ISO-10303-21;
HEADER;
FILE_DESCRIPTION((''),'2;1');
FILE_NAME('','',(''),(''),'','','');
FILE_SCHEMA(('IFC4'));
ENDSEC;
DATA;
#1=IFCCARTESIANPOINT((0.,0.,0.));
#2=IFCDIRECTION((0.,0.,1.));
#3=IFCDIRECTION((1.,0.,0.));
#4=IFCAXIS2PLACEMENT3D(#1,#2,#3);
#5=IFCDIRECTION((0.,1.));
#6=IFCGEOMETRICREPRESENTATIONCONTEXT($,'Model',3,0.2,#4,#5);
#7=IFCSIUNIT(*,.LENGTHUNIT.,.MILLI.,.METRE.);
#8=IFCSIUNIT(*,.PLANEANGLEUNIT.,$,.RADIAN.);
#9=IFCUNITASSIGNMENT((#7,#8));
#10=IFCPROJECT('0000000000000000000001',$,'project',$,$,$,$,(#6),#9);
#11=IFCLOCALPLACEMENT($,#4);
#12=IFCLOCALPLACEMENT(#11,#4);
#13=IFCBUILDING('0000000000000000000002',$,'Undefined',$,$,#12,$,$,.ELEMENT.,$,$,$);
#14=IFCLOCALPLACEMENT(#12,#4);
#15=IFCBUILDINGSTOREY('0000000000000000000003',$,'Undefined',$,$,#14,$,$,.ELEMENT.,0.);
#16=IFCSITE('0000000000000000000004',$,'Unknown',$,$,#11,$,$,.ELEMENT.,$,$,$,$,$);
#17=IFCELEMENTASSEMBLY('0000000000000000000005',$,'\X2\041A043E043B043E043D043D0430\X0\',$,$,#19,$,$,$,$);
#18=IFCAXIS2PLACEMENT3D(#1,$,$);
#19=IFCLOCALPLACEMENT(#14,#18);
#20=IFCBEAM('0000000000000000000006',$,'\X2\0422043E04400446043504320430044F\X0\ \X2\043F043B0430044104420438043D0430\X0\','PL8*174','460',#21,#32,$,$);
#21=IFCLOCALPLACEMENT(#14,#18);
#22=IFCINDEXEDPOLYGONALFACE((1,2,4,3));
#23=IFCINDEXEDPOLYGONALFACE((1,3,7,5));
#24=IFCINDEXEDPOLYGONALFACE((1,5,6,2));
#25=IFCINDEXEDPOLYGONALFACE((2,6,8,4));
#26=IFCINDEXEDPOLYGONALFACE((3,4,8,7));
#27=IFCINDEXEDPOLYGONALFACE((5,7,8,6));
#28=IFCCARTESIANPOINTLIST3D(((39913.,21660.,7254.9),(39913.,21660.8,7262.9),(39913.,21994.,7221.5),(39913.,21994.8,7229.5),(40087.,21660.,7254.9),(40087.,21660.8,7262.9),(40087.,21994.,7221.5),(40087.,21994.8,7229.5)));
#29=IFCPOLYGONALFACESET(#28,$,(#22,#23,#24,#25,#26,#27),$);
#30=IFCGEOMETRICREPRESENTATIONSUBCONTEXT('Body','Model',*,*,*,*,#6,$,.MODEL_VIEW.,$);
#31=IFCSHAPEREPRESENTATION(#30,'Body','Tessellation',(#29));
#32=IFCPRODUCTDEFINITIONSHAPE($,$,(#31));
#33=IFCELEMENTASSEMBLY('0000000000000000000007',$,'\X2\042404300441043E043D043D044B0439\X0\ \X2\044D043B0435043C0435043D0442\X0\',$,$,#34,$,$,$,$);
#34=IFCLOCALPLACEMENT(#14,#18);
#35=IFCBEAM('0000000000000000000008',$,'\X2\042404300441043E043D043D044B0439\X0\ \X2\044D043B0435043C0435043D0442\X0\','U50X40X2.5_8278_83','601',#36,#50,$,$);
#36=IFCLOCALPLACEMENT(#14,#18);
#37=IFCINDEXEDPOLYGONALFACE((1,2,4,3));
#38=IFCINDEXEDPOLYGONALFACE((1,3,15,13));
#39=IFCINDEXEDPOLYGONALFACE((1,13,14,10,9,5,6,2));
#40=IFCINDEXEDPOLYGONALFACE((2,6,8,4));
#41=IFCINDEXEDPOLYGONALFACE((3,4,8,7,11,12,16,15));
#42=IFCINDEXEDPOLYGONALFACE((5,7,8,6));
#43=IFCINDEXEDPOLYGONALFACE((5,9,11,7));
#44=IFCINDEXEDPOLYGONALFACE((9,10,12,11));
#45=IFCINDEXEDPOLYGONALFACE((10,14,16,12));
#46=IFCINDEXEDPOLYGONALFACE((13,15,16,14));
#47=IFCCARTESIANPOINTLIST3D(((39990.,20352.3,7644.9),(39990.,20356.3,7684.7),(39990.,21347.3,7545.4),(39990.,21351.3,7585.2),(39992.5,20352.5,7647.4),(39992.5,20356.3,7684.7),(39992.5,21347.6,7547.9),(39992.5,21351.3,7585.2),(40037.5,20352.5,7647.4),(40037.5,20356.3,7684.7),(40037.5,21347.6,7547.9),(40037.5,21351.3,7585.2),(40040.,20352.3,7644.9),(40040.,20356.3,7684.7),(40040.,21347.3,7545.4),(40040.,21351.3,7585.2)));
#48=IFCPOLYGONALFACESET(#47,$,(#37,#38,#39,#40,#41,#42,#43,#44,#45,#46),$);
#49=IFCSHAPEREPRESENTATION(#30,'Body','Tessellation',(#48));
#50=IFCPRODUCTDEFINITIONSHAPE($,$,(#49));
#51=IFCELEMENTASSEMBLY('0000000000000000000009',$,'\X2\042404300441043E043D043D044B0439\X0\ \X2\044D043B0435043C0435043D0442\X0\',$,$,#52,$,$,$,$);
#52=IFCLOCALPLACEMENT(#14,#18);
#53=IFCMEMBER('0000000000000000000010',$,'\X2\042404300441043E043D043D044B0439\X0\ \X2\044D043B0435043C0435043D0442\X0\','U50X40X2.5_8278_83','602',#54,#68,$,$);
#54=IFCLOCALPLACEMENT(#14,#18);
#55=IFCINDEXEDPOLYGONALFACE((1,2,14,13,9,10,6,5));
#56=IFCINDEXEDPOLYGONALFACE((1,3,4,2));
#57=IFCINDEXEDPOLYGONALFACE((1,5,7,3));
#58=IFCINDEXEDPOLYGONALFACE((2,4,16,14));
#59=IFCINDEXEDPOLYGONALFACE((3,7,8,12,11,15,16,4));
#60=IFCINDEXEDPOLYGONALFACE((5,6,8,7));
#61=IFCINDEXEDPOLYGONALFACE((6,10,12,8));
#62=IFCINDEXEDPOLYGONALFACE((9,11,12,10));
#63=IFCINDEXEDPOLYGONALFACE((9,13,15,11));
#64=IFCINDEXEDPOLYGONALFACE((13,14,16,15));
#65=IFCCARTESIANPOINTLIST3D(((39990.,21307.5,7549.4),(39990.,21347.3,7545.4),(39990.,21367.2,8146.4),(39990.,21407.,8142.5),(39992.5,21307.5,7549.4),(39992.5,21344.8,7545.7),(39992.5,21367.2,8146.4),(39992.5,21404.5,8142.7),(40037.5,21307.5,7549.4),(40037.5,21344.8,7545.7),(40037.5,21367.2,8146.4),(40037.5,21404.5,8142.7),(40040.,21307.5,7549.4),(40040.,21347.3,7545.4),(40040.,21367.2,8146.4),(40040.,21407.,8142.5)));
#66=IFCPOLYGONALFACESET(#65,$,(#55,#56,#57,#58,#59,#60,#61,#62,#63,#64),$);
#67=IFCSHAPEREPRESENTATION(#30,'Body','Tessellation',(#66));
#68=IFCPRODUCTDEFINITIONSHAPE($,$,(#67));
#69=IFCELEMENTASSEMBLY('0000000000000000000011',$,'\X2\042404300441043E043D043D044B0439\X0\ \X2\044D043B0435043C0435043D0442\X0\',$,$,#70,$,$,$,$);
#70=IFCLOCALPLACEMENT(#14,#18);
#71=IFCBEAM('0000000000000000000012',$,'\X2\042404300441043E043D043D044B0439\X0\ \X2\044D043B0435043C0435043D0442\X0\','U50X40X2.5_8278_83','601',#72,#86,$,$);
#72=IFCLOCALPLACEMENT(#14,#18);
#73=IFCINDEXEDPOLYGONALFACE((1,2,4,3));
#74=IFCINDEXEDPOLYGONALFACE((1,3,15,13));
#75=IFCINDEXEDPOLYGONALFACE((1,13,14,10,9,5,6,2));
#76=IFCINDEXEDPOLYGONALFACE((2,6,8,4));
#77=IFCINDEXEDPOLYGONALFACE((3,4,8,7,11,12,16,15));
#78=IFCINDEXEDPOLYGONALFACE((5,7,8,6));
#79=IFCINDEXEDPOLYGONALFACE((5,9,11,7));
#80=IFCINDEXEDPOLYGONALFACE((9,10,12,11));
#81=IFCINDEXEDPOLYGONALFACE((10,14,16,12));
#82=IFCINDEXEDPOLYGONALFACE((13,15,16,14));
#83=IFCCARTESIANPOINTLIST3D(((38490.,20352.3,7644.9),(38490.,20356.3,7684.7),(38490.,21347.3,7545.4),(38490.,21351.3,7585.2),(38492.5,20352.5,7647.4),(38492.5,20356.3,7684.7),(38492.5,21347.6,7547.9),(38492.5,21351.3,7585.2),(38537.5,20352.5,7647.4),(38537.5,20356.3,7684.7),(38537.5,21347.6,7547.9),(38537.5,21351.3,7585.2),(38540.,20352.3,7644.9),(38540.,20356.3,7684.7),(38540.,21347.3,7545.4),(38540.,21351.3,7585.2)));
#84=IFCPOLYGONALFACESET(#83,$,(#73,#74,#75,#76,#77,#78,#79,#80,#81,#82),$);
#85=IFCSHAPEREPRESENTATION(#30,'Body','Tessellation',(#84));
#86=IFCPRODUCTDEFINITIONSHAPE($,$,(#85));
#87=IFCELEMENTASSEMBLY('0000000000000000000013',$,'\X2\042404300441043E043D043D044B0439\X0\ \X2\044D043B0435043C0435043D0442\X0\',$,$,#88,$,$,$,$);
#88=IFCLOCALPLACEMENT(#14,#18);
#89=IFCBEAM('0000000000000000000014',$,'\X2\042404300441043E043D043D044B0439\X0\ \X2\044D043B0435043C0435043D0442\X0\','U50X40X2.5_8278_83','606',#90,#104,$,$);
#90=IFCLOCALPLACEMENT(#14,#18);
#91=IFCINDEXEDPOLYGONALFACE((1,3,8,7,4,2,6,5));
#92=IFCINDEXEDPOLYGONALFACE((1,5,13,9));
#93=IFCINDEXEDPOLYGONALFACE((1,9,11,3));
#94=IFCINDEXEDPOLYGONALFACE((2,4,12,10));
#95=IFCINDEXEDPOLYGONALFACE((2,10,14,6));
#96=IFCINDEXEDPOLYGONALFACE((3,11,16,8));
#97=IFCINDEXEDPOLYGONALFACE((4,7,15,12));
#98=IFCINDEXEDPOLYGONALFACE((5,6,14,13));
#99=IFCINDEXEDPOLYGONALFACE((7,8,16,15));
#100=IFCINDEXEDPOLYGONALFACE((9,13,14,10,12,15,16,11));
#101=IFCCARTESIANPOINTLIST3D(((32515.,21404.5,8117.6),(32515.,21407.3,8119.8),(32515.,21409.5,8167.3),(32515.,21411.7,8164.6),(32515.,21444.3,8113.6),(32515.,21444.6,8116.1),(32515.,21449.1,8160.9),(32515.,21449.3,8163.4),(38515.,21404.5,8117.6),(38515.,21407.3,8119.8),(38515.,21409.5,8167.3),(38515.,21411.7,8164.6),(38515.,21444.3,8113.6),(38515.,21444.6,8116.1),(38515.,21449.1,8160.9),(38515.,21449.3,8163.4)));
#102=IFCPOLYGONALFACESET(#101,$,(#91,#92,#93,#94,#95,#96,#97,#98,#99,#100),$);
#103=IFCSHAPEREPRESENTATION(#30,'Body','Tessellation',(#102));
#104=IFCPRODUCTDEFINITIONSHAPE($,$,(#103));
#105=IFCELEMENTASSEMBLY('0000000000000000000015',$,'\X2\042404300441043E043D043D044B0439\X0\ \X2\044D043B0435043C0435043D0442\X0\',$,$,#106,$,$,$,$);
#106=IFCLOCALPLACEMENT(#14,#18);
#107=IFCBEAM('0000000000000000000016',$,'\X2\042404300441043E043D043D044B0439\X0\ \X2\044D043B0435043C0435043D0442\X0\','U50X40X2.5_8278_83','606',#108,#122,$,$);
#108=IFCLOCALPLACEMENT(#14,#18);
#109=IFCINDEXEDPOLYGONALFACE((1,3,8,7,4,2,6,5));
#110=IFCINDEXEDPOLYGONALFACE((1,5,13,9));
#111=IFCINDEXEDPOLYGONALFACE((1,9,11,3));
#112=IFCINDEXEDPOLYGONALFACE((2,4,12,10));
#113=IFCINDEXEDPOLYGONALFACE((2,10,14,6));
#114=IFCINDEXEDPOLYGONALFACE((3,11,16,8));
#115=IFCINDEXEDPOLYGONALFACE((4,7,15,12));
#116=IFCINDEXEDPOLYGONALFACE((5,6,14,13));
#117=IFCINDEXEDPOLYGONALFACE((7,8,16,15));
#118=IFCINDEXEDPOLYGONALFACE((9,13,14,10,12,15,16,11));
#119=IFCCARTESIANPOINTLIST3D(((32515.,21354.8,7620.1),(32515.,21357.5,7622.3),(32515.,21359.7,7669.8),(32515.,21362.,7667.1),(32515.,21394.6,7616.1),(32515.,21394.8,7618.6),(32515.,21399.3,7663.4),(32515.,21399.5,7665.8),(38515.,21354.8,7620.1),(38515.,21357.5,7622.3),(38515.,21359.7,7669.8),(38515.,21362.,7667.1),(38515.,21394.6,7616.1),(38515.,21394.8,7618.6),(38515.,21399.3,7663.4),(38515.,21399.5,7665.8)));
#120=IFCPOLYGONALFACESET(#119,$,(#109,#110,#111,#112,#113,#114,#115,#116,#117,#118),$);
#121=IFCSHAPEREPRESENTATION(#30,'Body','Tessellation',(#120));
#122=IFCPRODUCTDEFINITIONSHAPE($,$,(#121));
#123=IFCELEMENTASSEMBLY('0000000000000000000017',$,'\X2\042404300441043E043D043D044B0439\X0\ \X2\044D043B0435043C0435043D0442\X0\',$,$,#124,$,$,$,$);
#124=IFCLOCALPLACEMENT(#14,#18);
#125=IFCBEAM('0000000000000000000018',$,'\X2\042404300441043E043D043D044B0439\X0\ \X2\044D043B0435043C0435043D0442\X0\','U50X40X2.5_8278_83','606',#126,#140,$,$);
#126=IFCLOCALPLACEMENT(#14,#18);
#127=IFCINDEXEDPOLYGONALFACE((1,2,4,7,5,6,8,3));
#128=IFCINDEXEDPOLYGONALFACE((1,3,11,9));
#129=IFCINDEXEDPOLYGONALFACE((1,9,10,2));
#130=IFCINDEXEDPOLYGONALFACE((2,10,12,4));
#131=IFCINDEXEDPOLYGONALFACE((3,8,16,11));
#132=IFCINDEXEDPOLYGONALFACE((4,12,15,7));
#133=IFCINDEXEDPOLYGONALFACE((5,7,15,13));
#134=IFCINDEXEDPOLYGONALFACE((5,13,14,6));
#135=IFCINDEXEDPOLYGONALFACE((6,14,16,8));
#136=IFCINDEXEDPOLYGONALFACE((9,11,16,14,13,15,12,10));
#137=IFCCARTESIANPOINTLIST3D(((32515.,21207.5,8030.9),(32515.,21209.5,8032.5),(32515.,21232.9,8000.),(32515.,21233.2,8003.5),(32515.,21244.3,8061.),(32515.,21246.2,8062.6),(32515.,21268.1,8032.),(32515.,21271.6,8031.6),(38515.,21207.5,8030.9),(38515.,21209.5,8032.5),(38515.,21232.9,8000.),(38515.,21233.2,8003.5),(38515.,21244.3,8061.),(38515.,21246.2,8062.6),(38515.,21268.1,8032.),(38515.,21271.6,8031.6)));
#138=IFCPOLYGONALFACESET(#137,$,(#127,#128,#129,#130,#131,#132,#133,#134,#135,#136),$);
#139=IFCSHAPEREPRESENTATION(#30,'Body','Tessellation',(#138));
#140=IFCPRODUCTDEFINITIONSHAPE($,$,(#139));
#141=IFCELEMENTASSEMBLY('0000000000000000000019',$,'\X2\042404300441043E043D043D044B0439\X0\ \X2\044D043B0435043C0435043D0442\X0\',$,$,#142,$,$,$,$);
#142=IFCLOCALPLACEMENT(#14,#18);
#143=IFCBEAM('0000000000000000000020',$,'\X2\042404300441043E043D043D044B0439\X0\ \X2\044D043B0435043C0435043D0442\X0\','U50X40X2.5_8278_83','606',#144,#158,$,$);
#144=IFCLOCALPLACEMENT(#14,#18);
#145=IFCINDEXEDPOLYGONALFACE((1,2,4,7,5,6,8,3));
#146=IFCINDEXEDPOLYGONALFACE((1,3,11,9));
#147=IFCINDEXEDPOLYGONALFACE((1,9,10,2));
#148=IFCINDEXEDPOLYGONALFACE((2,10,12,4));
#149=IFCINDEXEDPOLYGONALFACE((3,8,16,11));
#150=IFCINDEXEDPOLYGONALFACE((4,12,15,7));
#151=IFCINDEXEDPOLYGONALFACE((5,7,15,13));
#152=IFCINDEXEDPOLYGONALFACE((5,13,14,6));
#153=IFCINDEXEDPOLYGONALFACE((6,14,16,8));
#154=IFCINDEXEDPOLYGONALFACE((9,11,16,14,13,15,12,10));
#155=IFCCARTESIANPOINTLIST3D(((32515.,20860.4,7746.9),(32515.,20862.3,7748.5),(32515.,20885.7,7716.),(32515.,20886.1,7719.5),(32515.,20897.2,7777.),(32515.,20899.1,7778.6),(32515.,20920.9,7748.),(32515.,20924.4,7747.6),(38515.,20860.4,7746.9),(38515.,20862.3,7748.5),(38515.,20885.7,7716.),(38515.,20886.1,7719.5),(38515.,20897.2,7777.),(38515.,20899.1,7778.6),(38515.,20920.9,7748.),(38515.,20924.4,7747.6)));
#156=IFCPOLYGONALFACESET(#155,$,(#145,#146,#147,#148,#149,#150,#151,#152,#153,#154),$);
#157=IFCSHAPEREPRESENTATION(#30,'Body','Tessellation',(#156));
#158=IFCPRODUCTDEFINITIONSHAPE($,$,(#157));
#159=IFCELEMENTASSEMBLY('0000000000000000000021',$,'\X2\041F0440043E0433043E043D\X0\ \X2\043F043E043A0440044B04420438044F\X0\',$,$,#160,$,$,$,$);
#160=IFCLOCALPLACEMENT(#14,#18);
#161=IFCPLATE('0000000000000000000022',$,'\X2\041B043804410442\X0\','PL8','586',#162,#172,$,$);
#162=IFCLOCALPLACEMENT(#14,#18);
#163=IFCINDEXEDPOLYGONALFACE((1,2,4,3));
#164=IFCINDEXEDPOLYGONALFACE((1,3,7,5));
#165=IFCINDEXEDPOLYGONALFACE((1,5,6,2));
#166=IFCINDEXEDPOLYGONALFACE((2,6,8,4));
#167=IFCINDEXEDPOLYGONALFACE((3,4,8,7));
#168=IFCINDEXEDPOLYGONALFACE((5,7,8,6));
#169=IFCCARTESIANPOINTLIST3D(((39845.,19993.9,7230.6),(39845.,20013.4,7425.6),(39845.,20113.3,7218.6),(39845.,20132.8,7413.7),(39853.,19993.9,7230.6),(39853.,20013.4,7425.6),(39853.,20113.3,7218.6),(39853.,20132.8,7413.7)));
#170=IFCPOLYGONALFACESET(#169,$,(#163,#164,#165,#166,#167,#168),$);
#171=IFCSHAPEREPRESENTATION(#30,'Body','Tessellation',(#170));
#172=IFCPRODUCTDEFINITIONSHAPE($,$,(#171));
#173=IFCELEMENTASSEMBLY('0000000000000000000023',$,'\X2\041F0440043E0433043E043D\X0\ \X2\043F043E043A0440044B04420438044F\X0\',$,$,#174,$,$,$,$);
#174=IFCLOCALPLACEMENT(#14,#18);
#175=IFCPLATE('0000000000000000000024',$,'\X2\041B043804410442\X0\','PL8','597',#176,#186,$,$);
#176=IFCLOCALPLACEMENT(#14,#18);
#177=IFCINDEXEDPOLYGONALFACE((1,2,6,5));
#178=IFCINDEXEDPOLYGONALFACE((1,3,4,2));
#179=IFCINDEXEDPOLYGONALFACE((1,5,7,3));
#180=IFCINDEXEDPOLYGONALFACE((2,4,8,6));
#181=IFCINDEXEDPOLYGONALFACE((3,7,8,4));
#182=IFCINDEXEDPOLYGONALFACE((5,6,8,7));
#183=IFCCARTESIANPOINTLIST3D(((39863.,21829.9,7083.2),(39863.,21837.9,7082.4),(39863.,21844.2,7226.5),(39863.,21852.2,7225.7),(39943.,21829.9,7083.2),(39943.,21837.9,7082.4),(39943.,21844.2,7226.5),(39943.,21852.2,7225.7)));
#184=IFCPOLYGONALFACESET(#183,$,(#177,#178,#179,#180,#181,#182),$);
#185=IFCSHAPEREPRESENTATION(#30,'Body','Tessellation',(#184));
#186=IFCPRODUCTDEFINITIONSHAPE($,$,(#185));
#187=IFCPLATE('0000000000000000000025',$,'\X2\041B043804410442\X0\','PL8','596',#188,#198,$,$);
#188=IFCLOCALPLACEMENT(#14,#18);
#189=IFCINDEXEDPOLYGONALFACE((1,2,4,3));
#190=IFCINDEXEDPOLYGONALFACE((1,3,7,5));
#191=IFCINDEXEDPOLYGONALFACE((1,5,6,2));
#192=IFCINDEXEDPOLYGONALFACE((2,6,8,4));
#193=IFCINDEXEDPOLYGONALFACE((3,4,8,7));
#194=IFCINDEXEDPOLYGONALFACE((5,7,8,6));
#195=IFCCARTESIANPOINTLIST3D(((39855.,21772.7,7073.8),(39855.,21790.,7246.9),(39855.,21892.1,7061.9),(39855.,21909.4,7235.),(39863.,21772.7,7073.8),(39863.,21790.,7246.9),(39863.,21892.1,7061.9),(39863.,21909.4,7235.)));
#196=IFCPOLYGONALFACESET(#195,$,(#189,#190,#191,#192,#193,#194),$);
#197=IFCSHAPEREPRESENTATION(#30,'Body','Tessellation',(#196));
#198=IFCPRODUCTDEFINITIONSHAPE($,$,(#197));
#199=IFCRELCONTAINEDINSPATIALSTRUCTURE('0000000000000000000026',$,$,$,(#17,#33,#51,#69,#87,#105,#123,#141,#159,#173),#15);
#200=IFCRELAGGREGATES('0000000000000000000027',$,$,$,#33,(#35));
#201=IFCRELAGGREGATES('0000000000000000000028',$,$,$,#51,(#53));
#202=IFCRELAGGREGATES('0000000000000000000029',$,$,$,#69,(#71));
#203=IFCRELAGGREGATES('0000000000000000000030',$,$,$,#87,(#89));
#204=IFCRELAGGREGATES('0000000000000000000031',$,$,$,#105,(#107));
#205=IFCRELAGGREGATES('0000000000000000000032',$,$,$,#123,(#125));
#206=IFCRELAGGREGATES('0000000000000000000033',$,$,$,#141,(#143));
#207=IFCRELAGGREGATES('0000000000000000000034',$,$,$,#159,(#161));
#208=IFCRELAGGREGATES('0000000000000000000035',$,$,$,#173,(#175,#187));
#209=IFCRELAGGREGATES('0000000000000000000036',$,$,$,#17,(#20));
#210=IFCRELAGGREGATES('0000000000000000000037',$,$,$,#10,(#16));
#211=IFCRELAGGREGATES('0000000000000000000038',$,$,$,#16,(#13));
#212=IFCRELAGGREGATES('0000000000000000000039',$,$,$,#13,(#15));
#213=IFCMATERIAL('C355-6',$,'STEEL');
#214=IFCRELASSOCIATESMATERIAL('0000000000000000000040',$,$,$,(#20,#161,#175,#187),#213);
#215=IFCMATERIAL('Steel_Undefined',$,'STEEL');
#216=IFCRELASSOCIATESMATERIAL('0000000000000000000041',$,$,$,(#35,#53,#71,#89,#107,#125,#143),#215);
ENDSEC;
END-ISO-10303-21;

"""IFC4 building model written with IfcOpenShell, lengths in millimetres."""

from ifc_helpers import new_model, si_unit, direction, frame, origin_with_axes, place, context, subcontext, project, spatial, line, indexed_curve, outline, extrude, material, element, aggregate, save


model = new_model("IFC4")

# Units and contexts
model_context = context("Model", 3, precision=0.2, world=origin_with_axes(), true_north=direction((0.0, 1.0)))
body_context = subcontext(model_context, "Body", "Model", "MODEL_VIEW")
ifc_project = project(units=[si_unit("LENGTHUNIT", "METRE", prefix="MILLI"), si_unit("PLANEANGLEUNIT", "RADIAN")], contexts=[model_context])

# Site, building, storey
site_placement = place(None, origin_with_axes())
site = spatial("IfcSite", under=ifc_project, at=site_placement, Name="Unknown", CompositionType="ELEMENT")
building_placement = place(site_placement, origin_with_axes())
building = spatial("IfcBuilding", under=site, at=building_placement, Name="Undefined", CompositionType="ELEMENT")
storey_placement = place(building_placement, origin_with_axes())
storey = spatial("IfcBuildingStorey", under=building, at=storey_placement, Name="Undefined", CompositionType="ELEMENT", Elevation=0.0)

# Element assemblies, beams
assembly_1_placement = place(storey_placement, frame((40000.0, 21827.0, -200.0), z_axis=(-1.0, 0.0, 0.0), x_axis=(0.0, 0.0, 1.0)))
assembly_1 = element("IfcElementAssembly", 1, at=assembly_1_placement, inside=storey, Name="Колонна")
ifc_material_1 = material(Name="C355-6", Category="STEEL")
beam_1_placement = place(assembly_1_placement, frame((7458.9, -166.6, 0.0), z_axis=(-0.995037, -0.099504, 0.0), x_axis=(-0.099504, 0.995037, 0.0)))
beam_1 = element("IfcBeam", 2, at=beam_1_placement, material=ifc_material_1, Name="Торцевая пластина", Description="PL8*174", ObjectType="460", context=body_context, shape_type="SolidModel", body=[
    extrude(outline(indexed_curve([(-4.0, -87.0), (4.0, -87.0), (4.0, 87.0), (-4.0, 87.0)], segments=[line(1, 2, 3, 4, 1)])), frame((0.0, 0.0, 0.0), z_axis=(-1.0, 0.0, 0.0), x_axis=(0.0, 0.0, 1.0)), (0.0, 0.0, -1.0), 335.7),
])
assembly_2_placement = place(storey_placement, frame((40015.0, 21349.3, 7565.3), z_axis=(0.0, 0.099504, 0.995037), x_axis=(0.0, -0.995037, 0.099504)))
assembly_2 = element("IfcElementAssembly", 3, at=assembly_2_placement, inside=storey, Name="Фасонный элемент")
ifc_material_2 = material(Name="Steel_Undefined", Category="STEEL")
beam_2_placement = place(assembly_2_placement, origin_with_axes())
beam_2 = element("IfcBeam", 4, at=beam_2_placement, material=ifc_material_2, Name="Фасонный элемент", Description="U50X40X2.5_8278_83", ObjectType="601", context=body_context, shape_type="SolidModel", body=[
    extrude(outline(indexed_curve([(-20.0, -25.0), (20.0, -25.0), (20.0, -22.5), (-17.5, -22.5), (-17.5, 22.5), (20.0, 22.5), (20.0, 25.0), (-20.0, 25.0)], segments=[line(1, 2, 3, 4, 5, 6, 7, 8, 1)])), frame((0.0, 0.0, 0.0), z_axis=(-1.0, 0.0, 0.0), x_axis=(0.0, 0.0, 1.0)), (0.0, 0.0, -1.0), 1000.0),
])
aggregate(assembly_2, [beam_2])

# Element assembly, member
assembly_3_placement = place(storey_placement, frame((40015.0, 21327.4, 7547.4), z_axis=(0.0, -0.995037, 0.099504), x_axis=(0.0, 0.099504, 0.995037)))
assembly_3 = element("IfcElementAssembly", 5, at=assembly_3_placement, inside=storey, Name="Фасонный элемент")
member_placement = place(assembly_3_placement, origin_with_axes())
member = element("IfcMember", 6, at=member_placement, material=ifc_material_2, Name="Фасонный элемент", Description="U50X40X2.5_8278_83", ObjectType="602", context=body_context, shape_type="SolidModel", body=[
    extrude(outline(indexed_curve([(-20.0, -25.0), (20.0, -25.0), (20.0, -22.5), (-17.5, -22.5), (-17.5, 22.5), (20.0, 22.5), (20.0, 25.0), (-20.0, 25.0)], segments=[line(1, 2, 3, 4, 5, 6, 7, 8, 1)])), frame((0.0, 0.0, 0.0), z_axis=(-1.0, 0.0, 0.0), x_axis=(0.0, 0.0, 1.0)), (0.0, 0.0, -1.0), 600.0),
])
aggregate(assembly_3, [member])

# Element assemblies, beams
assembly_4_placement = place(storey_placement, frame((38515.0, 21349.3, 7565.3), z_axis=(0.0, 0.099504, 0.995037), x_axis=(0.0, -0.995037, 0.099504)))
assembly_4 = element("IfcElementAssembly", 7, at=assembly_4_placement, inside=storey, Name="Фасонный элемент")
beam_3_placement = place(assembly_4_placement, origin_with_axes())
beam_3 = element("IfcBeam", 8, at=beam_3_placement, material=ifc_material_2, Name="Фасонный элемент", Description="U50X40X2.5_8278_83", ObjectType="601", context=body_context, shape_type="SolidModel", body=[
    extrude(outline(indexed_curve([(-20.0, -25.0), (20.0, -25.0), (20.0, -22.5), (-17.5, -22.5), (-17.5, 22.5), (20.0, 22.5), (20.0, 25.0), (-20.0, 25.0)], segments=[line(1, 2, 3, 4, 5, 6, 7, 8, 1)])), frame((0.0, 0.0, 0.0), z_axis=(-1.0, 0.0, 0.0), x_axis=(0.0, 0.0, 1.0)), (0.0, 0.0, -1.0), 1000.0),
])
aggregate(assembly_4, [beam_3])
assembly_5_placement = place(storey_placement, frame((38515.0, 21426.9, 8140.5), z_axis=(0.0, 0.995037, -0.099504), x_axis=(-1.0, 0.0, 0.0)))
assembly_5 = element("IfcElementAssembly", 9, at=assembly_5_placement, inside=storey, Name="Фасонный элемент")
beam_4_placement = place(assembly_5_placement, origin_with_axes())
beam_4 = element("IfcBeam", 10, at=beam_4_placement, material=ifc_material_2, Name="Фасонный элемент", Description="U50X40X2.5_8278_83", ObjectType="606", context=body_context, shape_type="SolidModel", body=[
    extrude(outline(indexed_curve([(-20.0, -25.0), (20.0, -25.0), (20.0, -22.5), (-17.5, -22.5), (-17.5, 22.5), (20.0, 22.5), (20.0, 25.0), (-20.0, 25.0)], segments=[line(1, 2, 3, 4, 5, 6, 7, 8, 1)])), frame((0.0, 0.0, 0.0), z_axis=(-1.0, 0.0, 0.0), x_axis=(0.0, 0.0, 1.0)), (0.0, 0.0, -1.0), 6000.0),
])
aggregate(assembly_5, [beam_4])
assembly_6_placement = place(storey_placement, frame((38515.0, 21377.2, 7643.0), z_axis=(0.0, 0.995037, -0.099504), x_axis=(-1.0, 0.0, 0.0)))
assembly_6 = element("IfcElementAssembly", 11, at=assembly_6_placement, inside=storey, Name="Фасонный элемент")
beam_5_placement = place(assembly_6_placement, origin_with_axes())
beam_5 = element("IfcBeam", 12, at=beam_5_placement, material=ifc_material_2, Name="Фасонный элемент", Description="U50X40X2.5_8278_83", ObjectType="606", context=body_context, shape_type="SolidModel", body=[
    extrude(outline(indexed_curve([(-20.0, -25.0), (20.0, -25.0), (20.0, -22.5), (-17.5, -22.5), (-17.5, 22.5), (20.0, 22.5), (20.0, 25.0), (-20.0, 25.0)], segments=[line(1, 2, 3, 4, 5, 6, 7, 8, 1)])), frame((0.0, 0.0, 0.0), z_axis=(-1.0, 0.0, 0.0), x_axis=(0.0, 0.0, 1.0)), (0.0, 0.0, -1.0), 6000.0),
])
aggregate(assembly_6, [beam_5])
assembly_7_placement = place(storey_placement, frame((38515.0, 21239.6, 8031.3), z_axis=(0.0, -0.633238, 0.773957), x_axis=(-1.0, 0.0, 0.0)))
assembly_7 = element("IfcElementAssembly", 13, at=assembly_7_placement, inside=storey, Name="Фасонный элемент")
beam_6_placement = place(assembly_7_placement, origin_with_axes())
beam_6 = element("IfcBeam", 14, at=beam_6_placement, material=ifc_material_2, Name="Фасонный элемент", Description="U50X40X2.5_8278_83", ObjectType="606", context=body_context, shape_type="SolidModel", body=[
    extrude(outline(indexed_curve([(-20.0, -25.0), (20.0, -25.0), (20.0, -22.5), (-17.5, -22.5), (-17.5, 22.5), (20.0, 22.5), (20.0, 25.0), (-20.0, 25.0)], segments=[line(1, 2, 3, 4, 5, 6, 7, 8, 1)])), frame((0.0, 0.0, 0.0), z_axis=(-1.0, 0.0, 0.0), x_axis=(0.0, 0.0, 1.0)), (0.0, 0.0, -1.0), 6000.0),
])
aggregate(assembly_7, [beam_6])
assembly_8_placement = place(storey_placement, frame((38515.0, 20892.4, 7747.3), z_axis=(0.0, -0.633238, 0.773957), x_axis=(-1.0, 0.0, 0.0)))
assembly_8 = element("IfcElementAssembly", 15, at=assembly_8_placement, inside=storey, Name="Фасонный элемент")
beam_7_placement = place(assembly_8_placement, origin_with_axes())
beam_7 = element("IfcBeam", 16, at=beam_7_placement, material=ifc_material_2, Name="Фасонный элемент", Description="U50X40X2.5_8278_83", ObjectType="606", context=body_context, shape_type="SolidModel", body=[
    extrude(outline(indexed_curve([(-20.0, -25.0), (20.0, -25.0), (20.0, -22.5), (-17.5, -22.5), (-17.5, 22.5), (20.0, 22.5), (20.0, 25.0), (-20.0, 25.0)], segments=[line(1, 2, 3, 4, 5, 6, 7, 8, 1)])), frame((0.0, 0.0, 0.0), z_axis=(-1.0, 0.0, 0.0), x_axis=(0.0, 0.0, 1.0)), (0.0, 0.0, -1.0), 6000.0),
])
aggregate(assembly_8, [beam_7])

# Element assembly, plate
assembly_9_placement = place(storey_placement, frame((40000.0, 20063.3, 7322.1), z_axis=(0.0, -0.995037, 0.099504), x_axis=(-1.0, 0.0, 0.0)))
assembly_9 = element("IfcElementAssembly", 17, at=assembly_9_placement, inside=storey, Name="Прогон покрытия")
plate_1_placement = place(assembly_9_placement, frame((151.0, -98.0, -60.0), z_axis=(-1.0, 0.0, 0.0), x_axis=(0.0, 0.0, 1.0)))
plate_1 = element("IfcPlate", 18, at=plate_1_placement, material=ifc_material_1, Name="Лист", Description="PL8", ObjectType="586", context=body_context, shape_type="SolidModel", body=[
    extrude(outline(indexed_curve([(0.0, 0.0), (120.0, 0.0), (120.0, 196.0), (0.0, 196.0)], segments=[line(1, 2, 3, 4, 1)])), frame((0.0, 0.0, 4.0), z_axis=(0.0, 0.0, 1.0), x_axis=(1.0, 0.0, 0.0)), (0.0, 0.0, -1.0), 8.0),
])
aggregate(assembly_9, [plate_1])

# Element assembly, plates
assembly_10_placement = place(storey_placement, frame((40000.0, 21841.0, 7154.4), z_axis=(0.0, -0.995037, 0.099504), x_axis=(-1.0, 0.0, 0.0)))
assembly_10 = element("IfcElementAssembly", 19, at=assembly_10_placement, inside=storey, Name="Прогон покрытия")
plate_2_placement = place(assembly_10_placement, frame((57.0, -72.0, 0.0), z_axis=(0.0, 0.0, 1.0), x_axis=(1.0, 0.0, 0.0)))
plate_2 = element("IfcPlate", 20, at=plate_2_placement, material=ifc_material_1, Name="Лист", Description="PL8", ObjectType="597", context=body_context, shape_type="SolidModel", body=[
    extrude(outline(indexed_curve([(0.0, 0.0), (80.0, 0.0), (80.0, 144.0), (0.0, 144.0)], segments=[line(1, 2, 3, 4, 1)])), frame((0.0, 0.0, 4.0), z_axis=(0.0, 0.0, 1.0), x_axis=(1.0, 0.0, 0.0)), (0.0, 0.0, -1.0), 8.0),
])
plate_3_placement = place(assembly_10_placement, frame((141.0, -87.0, -60.0), z_axis=(-1.0, 0.0, 0.0), x_axis=(0.0, 0.0, 1.0)))
plate_3 = element("IfcPlate", 21, at=plate_3_placement, material=ifc_material_1, Name="Лист", Description="PL8", ObjectType="596", context=body_context, shape_type="SolidModel", body=[
    extrude(outline(indexed_curve([(0.0, 0.0), (120.0, 0.0), (120.0, 174.0), (0.0, 174.0)], segments=[line(1, 2, 3, 4, 1)])), frame((0.0, 0.0, 4.0), z_axis=(0.0, 0.0, 1.0), x_axis=(1.0, 0.0, 0.0)), (0.0, 0.0, -1.0), 8.0),
])
aggregate(assembly_10, [plate_2, plate_3])

aggregate(assembly_1, [beam_1])

save(model, "model.ifc")
